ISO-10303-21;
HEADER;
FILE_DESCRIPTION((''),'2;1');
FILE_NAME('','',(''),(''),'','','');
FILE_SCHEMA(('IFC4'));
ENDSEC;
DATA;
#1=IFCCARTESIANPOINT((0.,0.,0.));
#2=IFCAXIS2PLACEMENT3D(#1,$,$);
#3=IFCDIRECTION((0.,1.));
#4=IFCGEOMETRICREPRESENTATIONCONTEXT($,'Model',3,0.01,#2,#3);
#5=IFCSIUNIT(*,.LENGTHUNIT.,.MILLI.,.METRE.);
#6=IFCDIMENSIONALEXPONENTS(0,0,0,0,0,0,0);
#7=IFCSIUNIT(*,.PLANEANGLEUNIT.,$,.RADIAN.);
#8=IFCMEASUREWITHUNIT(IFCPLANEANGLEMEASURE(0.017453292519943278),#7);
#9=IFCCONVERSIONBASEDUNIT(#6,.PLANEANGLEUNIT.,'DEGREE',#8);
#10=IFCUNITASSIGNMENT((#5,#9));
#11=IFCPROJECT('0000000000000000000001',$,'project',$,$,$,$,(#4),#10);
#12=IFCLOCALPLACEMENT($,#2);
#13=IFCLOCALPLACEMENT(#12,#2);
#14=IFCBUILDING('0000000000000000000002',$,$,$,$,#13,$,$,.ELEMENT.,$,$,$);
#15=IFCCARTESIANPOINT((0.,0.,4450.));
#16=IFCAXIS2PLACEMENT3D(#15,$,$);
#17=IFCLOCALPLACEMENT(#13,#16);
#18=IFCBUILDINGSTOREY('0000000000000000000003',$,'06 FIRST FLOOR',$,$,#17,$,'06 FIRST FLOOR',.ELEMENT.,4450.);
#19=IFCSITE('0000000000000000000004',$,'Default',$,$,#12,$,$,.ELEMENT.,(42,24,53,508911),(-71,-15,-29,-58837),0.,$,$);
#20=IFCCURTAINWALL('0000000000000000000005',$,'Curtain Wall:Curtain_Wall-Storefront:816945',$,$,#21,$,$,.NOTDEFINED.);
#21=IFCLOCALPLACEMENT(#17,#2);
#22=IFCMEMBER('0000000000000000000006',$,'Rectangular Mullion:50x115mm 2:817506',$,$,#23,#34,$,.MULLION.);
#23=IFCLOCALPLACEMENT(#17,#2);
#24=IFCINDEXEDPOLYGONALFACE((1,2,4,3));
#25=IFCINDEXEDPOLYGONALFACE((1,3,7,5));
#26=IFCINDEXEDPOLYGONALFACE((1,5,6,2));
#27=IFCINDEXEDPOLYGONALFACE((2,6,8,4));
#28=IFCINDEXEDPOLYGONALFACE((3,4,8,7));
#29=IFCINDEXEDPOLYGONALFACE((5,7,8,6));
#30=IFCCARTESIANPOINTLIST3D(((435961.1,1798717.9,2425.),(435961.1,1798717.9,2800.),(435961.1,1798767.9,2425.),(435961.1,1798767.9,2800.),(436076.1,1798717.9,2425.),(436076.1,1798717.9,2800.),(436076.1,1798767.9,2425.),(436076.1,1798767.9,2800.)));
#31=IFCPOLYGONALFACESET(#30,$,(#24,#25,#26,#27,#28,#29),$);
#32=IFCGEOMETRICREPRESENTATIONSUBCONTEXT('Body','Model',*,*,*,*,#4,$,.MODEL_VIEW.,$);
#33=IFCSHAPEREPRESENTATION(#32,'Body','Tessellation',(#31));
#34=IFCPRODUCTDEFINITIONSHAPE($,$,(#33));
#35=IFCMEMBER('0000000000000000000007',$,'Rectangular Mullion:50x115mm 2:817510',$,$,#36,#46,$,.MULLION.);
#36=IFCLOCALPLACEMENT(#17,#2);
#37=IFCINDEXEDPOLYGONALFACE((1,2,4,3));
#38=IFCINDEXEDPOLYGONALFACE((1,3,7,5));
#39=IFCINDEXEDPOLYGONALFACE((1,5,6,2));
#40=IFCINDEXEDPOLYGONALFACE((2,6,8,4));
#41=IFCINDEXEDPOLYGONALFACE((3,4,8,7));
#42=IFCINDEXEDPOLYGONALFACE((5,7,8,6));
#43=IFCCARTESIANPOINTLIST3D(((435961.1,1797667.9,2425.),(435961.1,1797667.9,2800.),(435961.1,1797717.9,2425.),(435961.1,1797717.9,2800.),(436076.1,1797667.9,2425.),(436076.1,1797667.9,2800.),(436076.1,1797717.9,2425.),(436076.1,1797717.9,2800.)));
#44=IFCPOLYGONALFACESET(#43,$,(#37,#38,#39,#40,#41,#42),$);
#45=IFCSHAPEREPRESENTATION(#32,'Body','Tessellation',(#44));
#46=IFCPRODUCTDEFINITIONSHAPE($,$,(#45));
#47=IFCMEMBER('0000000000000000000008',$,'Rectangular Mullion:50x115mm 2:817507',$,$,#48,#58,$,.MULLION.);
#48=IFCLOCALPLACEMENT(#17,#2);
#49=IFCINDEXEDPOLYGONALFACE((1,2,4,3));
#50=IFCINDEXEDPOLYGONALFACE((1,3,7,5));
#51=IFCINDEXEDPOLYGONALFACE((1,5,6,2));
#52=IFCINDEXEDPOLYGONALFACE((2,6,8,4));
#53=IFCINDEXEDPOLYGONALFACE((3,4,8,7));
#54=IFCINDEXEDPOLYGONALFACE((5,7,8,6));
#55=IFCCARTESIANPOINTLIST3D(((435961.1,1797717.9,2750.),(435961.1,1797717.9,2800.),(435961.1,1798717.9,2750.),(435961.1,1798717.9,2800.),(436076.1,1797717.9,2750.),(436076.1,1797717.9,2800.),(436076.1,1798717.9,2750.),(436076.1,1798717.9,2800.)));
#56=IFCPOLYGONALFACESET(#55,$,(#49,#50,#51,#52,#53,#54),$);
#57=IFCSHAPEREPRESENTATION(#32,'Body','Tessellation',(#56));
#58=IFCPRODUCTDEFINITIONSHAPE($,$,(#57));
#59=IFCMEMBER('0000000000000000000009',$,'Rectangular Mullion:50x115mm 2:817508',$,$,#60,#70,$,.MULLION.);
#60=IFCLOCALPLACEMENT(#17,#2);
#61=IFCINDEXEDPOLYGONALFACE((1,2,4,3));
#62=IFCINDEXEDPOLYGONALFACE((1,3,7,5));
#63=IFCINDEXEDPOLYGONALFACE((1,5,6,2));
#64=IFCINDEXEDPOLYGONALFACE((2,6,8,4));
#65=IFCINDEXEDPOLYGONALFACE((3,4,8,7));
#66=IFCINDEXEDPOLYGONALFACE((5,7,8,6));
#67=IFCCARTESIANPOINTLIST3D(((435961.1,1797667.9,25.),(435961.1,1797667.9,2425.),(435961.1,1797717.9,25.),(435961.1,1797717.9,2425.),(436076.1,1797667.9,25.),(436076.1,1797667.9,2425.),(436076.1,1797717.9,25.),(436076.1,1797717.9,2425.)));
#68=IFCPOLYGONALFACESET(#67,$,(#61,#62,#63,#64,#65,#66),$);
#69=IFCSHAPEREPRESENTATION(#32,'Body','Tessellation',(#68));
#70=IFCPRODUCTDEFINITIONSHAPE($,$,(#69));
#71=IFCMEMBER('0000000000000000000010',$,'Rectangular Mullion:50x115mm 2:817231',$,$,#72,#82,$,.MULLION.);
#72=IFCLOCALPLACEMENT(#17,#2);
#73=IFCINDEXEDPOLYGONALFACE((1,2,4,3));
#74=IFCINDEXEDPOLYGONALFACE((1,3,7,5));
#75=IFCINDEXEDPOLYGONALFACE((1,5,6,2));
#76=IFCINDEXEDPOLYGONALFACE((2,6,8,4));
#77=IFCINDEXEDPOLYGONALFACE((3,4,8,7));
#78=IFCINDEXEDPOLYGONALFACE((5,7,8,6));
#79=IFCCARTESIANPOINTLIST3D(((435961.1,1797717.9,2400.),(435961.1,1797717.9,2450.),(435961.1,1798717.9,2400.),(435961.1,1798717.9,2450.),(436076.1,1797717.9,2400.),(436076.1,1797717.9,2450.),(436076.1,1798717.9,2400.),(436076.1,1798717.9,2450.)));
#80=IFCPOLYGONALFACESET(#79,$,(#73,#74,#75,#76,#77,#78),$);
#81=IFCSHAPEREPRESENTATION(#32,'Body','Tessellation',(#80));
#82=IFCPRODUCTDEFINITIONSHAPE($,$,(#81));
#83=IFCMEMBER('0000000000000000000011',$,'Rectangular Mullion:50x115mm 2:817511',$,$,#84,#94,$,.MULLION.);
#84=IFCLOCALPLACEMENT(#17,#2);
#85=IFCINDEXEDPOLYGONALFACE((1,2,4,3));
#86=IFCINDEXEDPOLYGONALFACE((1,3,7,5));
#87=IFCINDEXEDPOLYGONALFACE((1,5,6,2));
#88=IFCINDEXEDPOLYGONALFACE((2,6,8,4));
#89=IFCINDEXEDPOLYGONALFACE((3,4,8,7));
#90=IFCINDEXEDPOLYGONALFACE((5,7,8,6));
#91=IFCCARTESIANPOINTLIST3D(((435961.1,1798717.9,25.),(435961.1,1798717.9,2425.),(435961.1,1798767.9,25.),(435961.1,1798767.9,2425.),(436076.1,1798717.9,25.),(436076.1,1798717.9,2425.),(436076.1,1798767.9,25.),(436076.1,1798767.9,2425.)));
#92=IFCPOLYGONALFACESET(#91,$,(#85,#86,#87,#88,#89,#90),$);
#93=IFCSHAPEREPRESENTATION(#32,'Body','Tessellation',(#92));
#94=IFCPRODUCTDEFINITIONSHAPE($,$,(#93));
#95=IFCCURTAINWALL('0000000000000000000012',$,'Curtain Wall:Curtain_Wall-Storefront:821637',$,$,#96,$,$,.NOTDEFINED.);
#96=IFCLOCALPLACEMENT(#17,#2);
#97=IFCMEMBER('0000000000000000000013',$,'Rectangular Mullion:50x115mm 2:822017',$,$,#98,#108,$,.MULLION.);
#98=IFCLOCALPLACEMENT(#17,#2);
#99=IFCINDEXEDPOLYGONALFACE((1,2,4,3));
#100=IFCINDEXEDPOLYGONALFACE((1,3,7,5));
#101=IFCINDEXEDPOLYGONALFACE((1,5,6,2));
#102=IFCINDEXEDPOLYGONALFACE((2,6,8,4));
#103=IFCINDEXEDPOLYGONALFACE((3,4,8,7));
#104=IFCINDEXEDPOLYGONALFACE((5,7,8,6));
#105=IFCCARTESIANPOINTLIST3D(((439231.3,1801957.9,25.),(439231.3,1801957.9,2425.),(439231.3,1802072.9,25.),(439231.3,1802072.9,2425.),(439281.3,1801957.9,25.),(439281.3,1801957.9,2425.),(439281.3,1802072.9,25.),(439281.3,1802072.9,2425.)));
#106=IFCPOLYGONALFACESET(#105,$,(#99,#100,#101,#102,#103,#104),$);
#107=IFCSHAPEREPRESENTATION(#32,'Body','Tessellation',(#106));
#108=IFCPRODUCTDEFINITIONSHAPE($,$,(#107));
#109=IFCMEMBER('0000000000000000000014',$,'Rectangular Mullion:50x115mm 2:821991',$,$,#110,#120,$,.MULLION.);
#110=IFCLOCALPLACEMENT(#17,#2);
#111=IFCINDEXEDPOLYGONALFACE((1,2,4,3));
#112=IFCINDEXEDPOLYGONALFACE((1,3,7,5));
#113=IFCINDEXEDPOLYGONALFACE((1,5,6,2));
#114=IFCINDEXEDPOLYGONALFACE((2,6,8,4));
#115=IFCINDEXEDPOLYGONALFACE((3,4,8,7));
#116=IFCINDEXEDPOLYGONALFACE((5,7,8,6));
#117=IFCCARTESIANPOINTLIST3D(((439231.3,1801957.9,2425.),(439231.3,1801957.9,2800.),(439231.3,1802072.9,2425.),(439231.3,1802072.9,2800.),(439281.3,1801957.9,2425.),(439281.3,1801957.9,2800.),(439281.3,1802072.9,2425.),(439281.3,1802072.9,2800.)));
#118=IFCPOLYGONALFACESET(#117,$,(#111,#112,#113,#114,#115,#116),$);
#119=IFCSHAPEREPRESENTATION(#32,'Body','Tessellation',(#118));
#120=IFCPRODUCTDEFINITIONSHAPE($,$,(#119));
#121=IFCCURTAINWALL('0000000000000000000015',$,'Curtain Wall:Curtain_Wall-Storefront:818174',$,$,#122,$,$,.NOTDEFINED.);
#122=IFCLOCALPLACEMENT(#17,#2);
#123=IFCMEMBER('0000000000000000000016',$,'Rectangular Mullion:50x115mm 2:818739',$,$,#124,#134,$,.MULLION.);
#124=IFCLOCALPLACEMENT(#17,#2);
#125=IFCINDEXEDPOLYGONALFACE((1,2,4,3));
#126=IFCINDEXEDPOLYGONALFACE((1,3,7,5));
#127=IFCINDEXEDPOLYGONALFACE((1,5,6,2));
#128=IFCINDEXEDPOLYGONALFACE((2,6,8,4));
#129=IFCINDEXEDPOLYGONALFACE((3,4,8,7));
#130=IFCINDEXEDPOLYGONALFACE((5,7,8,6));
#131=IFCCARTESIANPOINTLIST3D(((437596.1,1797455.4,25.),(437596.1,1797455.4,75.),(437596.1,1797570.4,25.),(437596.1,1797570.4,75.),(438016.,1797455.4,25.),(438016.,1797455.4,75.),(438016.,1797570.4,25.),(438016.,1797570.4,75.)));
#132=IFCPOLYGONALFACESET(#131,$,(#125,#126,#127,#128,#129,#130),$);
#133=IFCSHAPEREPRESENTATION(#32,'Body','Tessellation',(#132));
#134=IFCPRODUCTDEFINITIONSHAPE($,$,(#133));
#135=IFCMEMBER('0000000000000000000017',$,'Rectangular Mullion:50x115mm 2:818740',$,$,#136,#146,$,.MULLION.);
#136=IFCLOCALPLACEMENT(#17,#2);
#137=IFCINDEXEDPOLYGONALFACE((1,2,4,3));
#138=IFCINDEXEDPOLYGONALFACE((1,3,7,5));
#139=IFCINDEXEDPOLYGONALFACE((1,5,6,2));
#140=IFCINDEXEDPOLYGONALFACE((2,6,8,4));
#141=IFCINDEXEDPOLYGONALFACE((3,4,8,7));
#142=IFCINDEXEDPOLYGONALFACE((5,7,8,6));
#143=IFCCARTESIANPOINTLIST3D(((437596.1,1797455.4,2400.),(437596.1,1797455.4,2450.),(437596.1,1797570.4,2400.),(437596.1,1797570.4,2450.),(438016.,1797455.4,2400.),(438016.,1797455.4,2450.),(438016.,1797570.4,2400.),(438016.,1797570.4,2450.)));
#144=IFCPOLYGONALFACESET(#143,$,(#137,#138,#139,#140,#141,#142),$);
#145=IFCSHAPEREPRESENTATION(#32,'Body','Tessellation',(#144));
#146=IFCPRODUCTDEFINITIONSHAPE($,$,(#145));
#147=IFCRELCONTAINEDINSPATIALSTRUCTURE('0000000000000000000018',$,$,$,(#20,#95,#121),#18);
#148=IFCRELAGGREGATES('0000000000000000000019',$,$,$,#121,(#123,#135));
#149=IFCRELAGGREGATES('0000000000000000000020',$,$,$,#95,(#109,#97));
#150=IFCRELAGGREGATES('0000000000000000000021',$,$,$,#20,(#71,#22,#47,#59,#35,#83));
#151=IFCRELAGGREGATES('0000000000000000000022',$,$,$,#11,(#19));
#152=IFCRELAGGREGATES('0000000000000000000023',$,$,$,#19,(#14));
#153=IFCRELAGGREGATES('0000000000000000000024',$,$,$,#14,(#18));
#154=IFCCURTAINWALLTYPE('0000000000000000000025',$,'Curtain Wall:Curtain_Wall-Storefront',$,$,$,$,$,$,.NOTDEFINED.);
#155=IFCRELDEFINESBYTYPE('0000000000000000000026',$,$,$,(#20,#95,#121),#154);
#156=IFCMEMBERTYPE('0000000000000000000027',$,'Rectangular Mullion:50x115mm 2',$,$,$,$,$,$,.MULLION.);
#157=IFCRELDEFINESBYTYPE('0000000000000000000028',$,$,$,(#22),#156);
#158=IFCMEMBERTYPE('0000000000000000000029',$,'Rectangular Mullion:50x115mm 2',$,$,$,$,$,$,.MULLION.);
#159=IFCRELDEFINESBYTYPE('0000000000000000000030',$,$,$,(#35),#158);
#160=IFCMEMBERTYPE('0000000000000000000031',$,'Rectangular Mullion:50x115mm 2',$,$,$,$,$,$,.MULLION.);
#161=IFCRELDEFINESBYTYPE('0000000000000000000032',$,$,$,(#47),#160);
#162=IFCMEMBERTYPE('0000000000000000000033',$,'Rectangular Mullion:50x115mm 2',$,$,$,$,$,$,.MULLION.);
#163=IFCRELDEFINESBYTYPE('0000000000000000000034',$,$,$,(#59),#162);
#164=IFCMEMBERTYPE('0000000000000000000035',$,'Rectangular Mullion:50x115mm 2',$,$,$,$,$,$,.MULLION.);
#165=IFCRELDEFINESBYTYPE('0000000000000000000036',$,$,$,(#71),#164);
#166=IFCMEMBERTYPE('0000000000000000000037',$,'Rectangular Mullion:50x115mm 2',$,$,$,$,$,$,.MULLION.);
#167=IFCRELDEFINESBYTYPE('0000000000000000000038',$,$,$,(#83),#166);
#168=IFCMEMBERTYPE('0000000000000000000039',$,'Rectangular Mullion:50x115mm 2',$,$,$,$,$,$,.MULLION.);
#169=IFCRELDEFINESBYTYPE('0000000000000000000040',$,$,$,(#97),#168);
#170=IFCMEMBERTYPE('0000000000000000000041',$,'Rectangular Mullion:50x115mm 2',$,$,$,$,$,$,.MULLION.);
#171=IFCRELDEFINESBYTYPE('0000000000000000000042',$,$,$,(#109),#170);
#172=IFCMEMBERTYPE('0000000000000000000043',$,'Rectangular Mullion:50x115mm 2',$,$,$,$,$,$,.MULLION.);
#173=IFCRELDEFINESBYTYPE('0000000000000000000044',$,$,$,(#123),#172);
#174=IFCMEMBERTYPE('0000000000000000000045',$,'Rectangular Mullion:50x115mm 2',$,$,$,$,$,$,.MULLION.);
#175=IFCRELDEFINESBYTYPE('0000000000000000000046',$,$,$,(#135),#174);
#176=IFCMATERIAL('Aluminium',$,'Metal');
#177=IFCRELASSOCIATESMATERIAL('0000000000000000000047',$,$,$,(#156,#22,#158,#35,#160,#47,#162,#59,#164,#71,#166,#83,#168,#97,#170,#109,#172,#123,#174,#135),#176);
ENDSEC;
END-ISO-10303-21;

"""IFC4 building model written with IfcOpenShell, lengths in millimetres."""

from ifc_helpers import new_model, entity, si_unit, converted_unit, direction, frame, origin, place, context, subcontext, project, spatial, indexed_curve, outline, extrude, source, transform, mapped, material, type_object, type_shapes, element, aggregate, save


model = new_model("IFC4")

# Units and contexts
model_context = context("Model", 3, precision=0.01, world=origin(), true_north=direction((0.0, 1.0)))
body_context = subcontext(model_context, "Body", "Model", "MODEL_VIEW")
ifc_project = project(units=[si_unit("LENGTHUNIT", "METRE", prefix="MILLI"), converted_unit("PLANEANGLEUNIT", "DEGREE", entity("IfcPlaneAngleMeasure", 0.017453292519943278), si_unit("PLANEANGLEUNIT", "RADIAN"), dimensions=[0, 0, 0, 0, 0, 0, 0])], contexts=[model_context])

# Site, building, storey
site_placement = place(None, origin())
site = spatial("IfcSite", under=ifc_project, at=site_placement, Name="Default", CompositionType="ELEMENT", RefLatitude=(42, 24, 53, 508911), RefLongitude=(-71, -15, -29, -58837), RefElevation=0.0)
building_placement = place(site_placement, origin())
building = spatial("IfcBuilding", under=site, at=building_placement, CompositionType="ELEMENT")
storey_placement = place(building_placement, frame((0.0, 0.0, 4450.0)))
storey = spatial("IfcBuildingStorey", under=building, at=storey_placement, Name="06 FIRST FLOOR", LongName="06 FIRST FLOOR", CompositionType="ELEMENT", Elevation=4450.0)

# Curtain walls, members
curtain_wall_type = type_object("IfcCurtainWallType", Name="Curtain Wall:Curtain_Wall-Storefront", PredefinedType="NOTDEFINED")
curtain_wall_1_placement = place(storey_placement, frame((0.0, 0.0, -4450.0)))
curtain_wall_1 = element("IfcCurtainWall", 1, at=curtain_wall_1_placement, inside=storey, type_object=curtain_wall_type, Name="Curtain Wall:Curtain_Wall-Storefront:816945", PredefinedType="NOTDEFINED")
ifc_material_1 = material(Name="Aluminium", Category="Metal")
member_type_1 = type_object("IfcMemberType", Name="Rectangular Mullion:50x115mm 2", PredefinedType="MULLION", material=ifc_material_1)
shared_shape_1 = source(origin(), body_context, "Body", "SweptSolid", [
    extrude(outline(indexed_curve([(-25.0, -57.5), (25.0, -57.5), (25.0, 57.5), (-25.0, 57.5), (-25.0, -57.5)], self_intersect=False)), frame((-25.0, 0.0, -375.0), z_axis=(0.0, 0.0, 1.0), x_axis=(-1.0, 0.0, 0.0)), (0.0, 0.0, 1.0), 375.0),
])
type_shapes(member_type_1, [shared_shape_1])
member_1_placement = place(curtain_wall_1_placement, frame((436018.6, 1798767.9, 7250.0), z_axis=(0.0, 0.0, 1.0), x_axis=(0.0, 1.0, 0.0)))
member_1 = element("IfcMember", 2, at=member_1_placement, type_object=member_type_1, material=ifc_material_1, Name="Rectangular Mullion:50x115mm 2:817506", PredefinedType="MULLION", context=body_context, shape_type="MappedRepresentation", body=[
    mapped(shared_shape_1, transform((0.0, 0.0, 0.0), scale=1.0)),
])
member_type_2 = type_object("IfcMemberType", Name="Rectangular Mullion:50x115mm 2", PredefinedType="MULLION", material=ifc_material_1)
shared_shape_2 = source(origin(), body_context, "Body", "SweptSolid", [
    extrude(outline(indexed_curve([(-25.0, -57.5), (25.0, -57.5), (25.0, 57.5), (-25.0, 57.5), (-25.0, -57.5)], self_intersect=False)), frame((-25.0, 0.0, -375.0), z_axis=(0.0, 0.0, 1.0), x_axis=(-1.0, 0.0, 0.0)), (0.0, 0.0, 1.0), 375.0),
])
type_shapes(member_type_2, [shared_shape_2])
member_2_placement = place(curtain_wall_1_placement, frame((436018.6, 1797667.9, 6875.0), z_axis=(0.0, 0.0, -1.0), x_axis=(0.0, -1.0, 0.0)))
member_2 = element("IfcMember", 3, at=member_2_placement, type_object=member_type_2, material=ifc_material_1, Name="Rectangular Mullion:50x115mm 2:817510", PredefinedType="MULLION", context=body_context, shape_type="MappedRepresentation", body=[
    mapped(shared_shape_2, transform((0.0, 0.0, 0.0), scale=1.0)),
])
member_type_3 = type_object("IfcMemberType", Name="Rectangular Mullion:50x115mm 2", PredefinedType="MULLION", material=ifc_material_1)
shared_shape_3 = source(origin(), body_context, "Body", "SweptSolid", [
    extrude(outline(indexed_curve([(-25.0, -57.5), (25.0, -57.5), (25.0, 57.5), (-25.0, 57.5), (-25.0, -57.5)], self_intersect=False)), frame((-25.0, 0.0, -1000.0), z_axis=(0.0, 0.0, 1.0), x_axis=(-1.0, 0.0, 0.0)), (0.0, 0.0, 1.0), 1000.0),
])
type_shapes(member_type_3, [shared_shape_3])
member_3_placement = place(curtain_wall_1_placement, frame((436018.6, 1797717.9, 7250.0), z_axis=(0.0, -1.0, 0.0), x_axis=(0.0, 0.0, 1.0)))
member_3 = element("IfcMember", 4, at=member_3_placement, type_object=member_type_3, material=ifc_material_1, Name="Rectangular Mullion:50x115mm 2:817507", PredefinedType="MULLION", context=body_context, shape_type="MappedRepresentation", body=[
    mapped(shared_shape_3, transform((0.0, 0.0, 0.0), scale=1.0)),
])
member_type_4 = type_object("IfcMemberType", Name="Rectangular Mullion:50x115mm 2", PredefinedType="MULLION", material=ifc_material_1)
shared_shape_4 = source(origin(), body_context, "Body", "SweptSolid", [
    extrude(outline(indexed_curve([(-25.0, -57.5), (25.0, -57.5), (25.0, 57.5), (-25.0, 57.5), (-25.0, -57.5)], self_intersect=False)), frame((-25.0, 0.0, -2400.0), z_axis=(0.0, 0.0, 1.0), x_axis=(-1.0, 0.0, 0.0)), (0.0, 0.0, 1.0), 2400.0),
])
type_shapes(member_type_4, [shared_shape_4])
member_4_placement = place(curtain_wall_1_placement, frame((436018.6, 1797667.9, 4475.0), z_axis=(0.0, 0.0, -1.0), x_axis=(0.0, -1.0, 0.0)))
member_4 = element("IfcMember", 5, at=member_4_placement, type_object=member_type_4, material=ifc_material_1, Name="Rectangular Mullion:50x115mm 2:817508", PredefinedType="MULLION", context=body_context, shape_type="MappedRepresentation", body=[
    mapped(shared_shape_4, transform((0.0, 0.0, 0.0), scale=1.0)),
])
member_type_5 = type_object("IfcMemberType", Name="Rectangular Mullion:50x115mm 2", PredefinedType="MULLION", material=ifc_material_1)
shared_shape_5 = source(origin(), body_context, "Body", "SweptSolid", [
    extrude(outline(indexed_curve([(-25.0, -57.5), (25.0, -57.5), (25.0, 57.5), (-25.0, 57.5), (-25.0, -57.5)], self_intersect=False)), frame((0.0, 0.0, -1000.0), z_axis=(0.0, 0.0, 1.0), x_axis=(-1.0, 0.0, 0.0)), (0.0, 0.0, 1.0), 1000.0),
])
type_shapes(member_type_5, [shared_shape_5])
member_5_placement = place(curtain_wall_1_placement, frame((436018.6, 1797717.9, 6875.0), z_axis=(0.0, -1.0, 0.0), x_axis=(0.0, 0.0, 1.0)))
member_5 = element("IfcMember", 6, at=member_5_placement, type_object=member_type_5, material=ifc_material_1, Name="Rectangular Mullion:50x115mm 2:817231", PredefinedType="MULLION", context=body_context, shape_type="MappedRepresentation", body=[
    mapped(shared_shape_5, transform((0.0, 0.0, 0.0), scale=1.0)),
])
member_type_6 = type_object("IfcMemberType", Name="Rectangular Mullion:50x115mm 2", PredefinedType="MULLION", material=ifc_material_1)
shared_shape_6 = source(origin(), body_context, "Body", "SweptSolid", [
    extrude(outline(indexed_curve([(-25.0, -57.5), (25.0, -57.5), (25.0, 57.5), (-25.0, 57.5), (-25.0, -57.5)], self_intersect=False)), frame((-25.0, 0.0, -2400.0), z_axis=(0.0, 0.0, 1.0), x_axis=(-1.0, 0.0, 0.0)), (0.0, 0.0, 1.0), 2400.0),
])
type_shapes(member_type_6, [shared_shape_6])
member_6_placement = place(curtain_wall_1_placement, frame((436018.6, 1798767.9, 6875.0), z_axis=(0.0, 0.0, 1.0), x_axis=(0.0, 1.0, 0.0)))
member_6 = element("IfcMember", 7, at=member_6_placement, type_object=member_type_6, material=ifc_material_1, Name="Rectangular Mullion:50x115mm 2:817511", PredefinedType="MULLION", context=body_context, shape_type="MappedRepresentation", body=[
    mapped(shared_shape_6, transform((0.0, 0.0, 0.0), scale=1.0)),
])
curtain_wall_2_placement = place(storey_placement, frame((0.0, 0.0, -4450.0)))
curtain_wall_2 = element("IfcCurtainWall", 8, at=curtain_wall_2_placement, inside=storey, type_object=curtain_wall_type, Name="Curtain Wall:Curtain_Wall-Storefront:821637", PredefinedType="NOTDEFINED")
member_type_7 = type_object("IfcMemberType", Name="Rectangular Mullion:50x115mm 2", PredefinedType="MULLION", material=ifc_material_1)
shared_shape_7 = source(origin(), body_context, "Body", "SweptSolid", [
    extrude(outline(indexed_curve([(-25.0, -57.5), (25.0, -57.5), (25.0, 57.5), (-25.0, 57.5), (-25.0, -57.5)], self_intersect=False)), frame((-25.0, 0.0, -2400.0), z_axis=(0.0, 0.0, 1.0), x_axis=(-1.0, 0.0, 0.0)), (0.0, 0.0, 1.0), 2400.0),
])
type_shapes(member_type_7, [shared_shape_7])
member_7_placement = place(curtain_wall_2_placement, frame((439231.3, 1802015.4, 6875.0), z_axis=(0.0, 0.0, 1.0), x_axis=(-1.0, 0.0, 0.0)))
member_7 = element("IfcMember", 9, at=member_7_placement, type_object=member_type_7, material=ifc_material_1, Name="Rectangular Mullion:50x115mm 2:822017", PredefinedType="MULLION", context=body_context, shape_type="MappedRepresentation", body=[
    mapped(shared_shape_7, transform((0.0, 0.0, 0.0), scale=1.0)),
])
member_type_8 = type_object("IfcMemberType", Name="Rectangular Mullion:50x115mm 2", PredefinedType="MULLION", material=ifc_material_1)
shared_shape_8 = source(origin(), body_context, "Body", "SweptSolid", [
    extrude(outline(indexed_curve([(-25.0, -57.5), (25.0, -57.5), (25.0, 57.5), (-25.0, 57.5), (-25.0, -57.5)], self_intersect=False)), frame((-25.0, 0.0, -375.0), z_axis=(0.0, 0.0, 1.0), x_axis=(-1.0, 0.0, 0.0)), (0.0, 0.0, 1.0), 375.0),
])
type_shapes(member_type_8, [shared_shape_8])
member_8_placement = place(curtain_wall_2_placement, frame((439231.3, 1802015.4, 7250.0), z_axis=(0.0, 0.0, 1.0), x_axis=(-1.0, 0.0, 0.0)))
member_8 = element("IfcMember", 10, at=member_8_placement, type_object=member_type_8, material=ifc_material_1, Name="Rectangular Mullion:50x115mm 2:821991", PredefinedType="MULLION", context=body_context, shape_type="MappedRepresentation", body=[
    mapped(shared_shape_8, transform((0.0, 0.0, 0.0), scale=1.0)),
])
curtain_wall_3_placement = place(storey_placement, frame((0.0, 0.0, -4450.0)))
curtain_wall_3 = element("IfcCurtainWall", 11, at=curtain_wall_3_placement, inside=storey, type_object=curtain_wall_type, Name="Curtain Wall:Curtain_Wall-Storefront:818174", PredefinedType="NOTDEFINED")
member_type_9 = type_object("IfcMemberType", Name="Rectangular Mullion:50x115mm 2", PredefinedType="MULLION", material=ifc_material_1)
shared_shape_9 = source(origin(), body_context, "Body", "SweptSolid", [
    extrude(outline(indexed_curve([(-25.0, -57.5), (25.0, -57.5), (25.0, 57.5), (-25.0, 57.5), (-25.0, -57.5)], self_intersect=False)), frame((-25.0, 0.0, -420.0), z_axis=(0.0, 0.0, 1.0), x_axis=(-1.0, 0.0, 0.0)), (0.0, 0.0, 1.0), 420.0),
])
type_shapes(member_type_9, [shared_shape_9])
member_9_placement = place(curtain_wall_3_placement, frame((437596.1, 1797512.9, 4475.0), z_axis=(-1.0, 0.0, 0.0), x_axis=(0.0, 0.0, -1.0)))
member_9 = element("IfcMember", 12, at=member_9_placement, type_object=member_type_9, material=ifc_material_1, Name="Rectangular Mullion:50x115mm 2:818739", PredefinedType="MULLION", context=body_context, shape_type="MappedRepresentation", body=[
    mapped(shared_shape_9, transform((0.0, 0.0, 0.0), scale=1.0)),
])
member_type_10 = type_object("IfcMemberType", Name="Rectangular Mullion:50x115mm 2", PredefinedType="MULLION", material=ifc_material_1)
shared_shape_10 = source(origin(), body_context, "Body", "SweptSolid", [
    extrude(outline(indexed_curve([(-25.0, -57.5), (25.0, -57.5), (25.0, 57.5), (-25.0, 57.5), (-25.0, -57.5)], self_intersect=False)), frame((0.0, 0.0, -420.0), z_axis=(0.0, 0.0, 1.0), x_axis=(-1.0, 0.0, 0.0)), (0.0, 0.0, 1.0), 420.0),
])
type_shapes(member_type_10, [shared_shape_10])
member_10_placement = place(curtain_wall_3_placement, frame((438016.0, 1797512.9, 6875.0), z_axis=(1.0, 0.0, 0.0), x_axis=(0.0, 0.0, 1.0)))
member_10 = element("IfcMember", 13, at=member_10_placement, type_object=member_type_10, material=ifc_material_1, Name="Rectangular Mullion:50x115mm 2:818740", PredefinedType="MULLION", context=body_context, shape_type="MappedRepresentation", body=[
    mapped(shared_shape_10, transform((0.0, 0.0, 0.0), scale=1.0)),
])
aggregate(curtain_wall_3, [member_9, member_10])

aggregate(curtain_wall_2, [member_8, member_7])

aggregate(curtain_wall_1, [member_5, member_1, member_3, member_4, member_2, member_6])

save(model, "model.ifc")
